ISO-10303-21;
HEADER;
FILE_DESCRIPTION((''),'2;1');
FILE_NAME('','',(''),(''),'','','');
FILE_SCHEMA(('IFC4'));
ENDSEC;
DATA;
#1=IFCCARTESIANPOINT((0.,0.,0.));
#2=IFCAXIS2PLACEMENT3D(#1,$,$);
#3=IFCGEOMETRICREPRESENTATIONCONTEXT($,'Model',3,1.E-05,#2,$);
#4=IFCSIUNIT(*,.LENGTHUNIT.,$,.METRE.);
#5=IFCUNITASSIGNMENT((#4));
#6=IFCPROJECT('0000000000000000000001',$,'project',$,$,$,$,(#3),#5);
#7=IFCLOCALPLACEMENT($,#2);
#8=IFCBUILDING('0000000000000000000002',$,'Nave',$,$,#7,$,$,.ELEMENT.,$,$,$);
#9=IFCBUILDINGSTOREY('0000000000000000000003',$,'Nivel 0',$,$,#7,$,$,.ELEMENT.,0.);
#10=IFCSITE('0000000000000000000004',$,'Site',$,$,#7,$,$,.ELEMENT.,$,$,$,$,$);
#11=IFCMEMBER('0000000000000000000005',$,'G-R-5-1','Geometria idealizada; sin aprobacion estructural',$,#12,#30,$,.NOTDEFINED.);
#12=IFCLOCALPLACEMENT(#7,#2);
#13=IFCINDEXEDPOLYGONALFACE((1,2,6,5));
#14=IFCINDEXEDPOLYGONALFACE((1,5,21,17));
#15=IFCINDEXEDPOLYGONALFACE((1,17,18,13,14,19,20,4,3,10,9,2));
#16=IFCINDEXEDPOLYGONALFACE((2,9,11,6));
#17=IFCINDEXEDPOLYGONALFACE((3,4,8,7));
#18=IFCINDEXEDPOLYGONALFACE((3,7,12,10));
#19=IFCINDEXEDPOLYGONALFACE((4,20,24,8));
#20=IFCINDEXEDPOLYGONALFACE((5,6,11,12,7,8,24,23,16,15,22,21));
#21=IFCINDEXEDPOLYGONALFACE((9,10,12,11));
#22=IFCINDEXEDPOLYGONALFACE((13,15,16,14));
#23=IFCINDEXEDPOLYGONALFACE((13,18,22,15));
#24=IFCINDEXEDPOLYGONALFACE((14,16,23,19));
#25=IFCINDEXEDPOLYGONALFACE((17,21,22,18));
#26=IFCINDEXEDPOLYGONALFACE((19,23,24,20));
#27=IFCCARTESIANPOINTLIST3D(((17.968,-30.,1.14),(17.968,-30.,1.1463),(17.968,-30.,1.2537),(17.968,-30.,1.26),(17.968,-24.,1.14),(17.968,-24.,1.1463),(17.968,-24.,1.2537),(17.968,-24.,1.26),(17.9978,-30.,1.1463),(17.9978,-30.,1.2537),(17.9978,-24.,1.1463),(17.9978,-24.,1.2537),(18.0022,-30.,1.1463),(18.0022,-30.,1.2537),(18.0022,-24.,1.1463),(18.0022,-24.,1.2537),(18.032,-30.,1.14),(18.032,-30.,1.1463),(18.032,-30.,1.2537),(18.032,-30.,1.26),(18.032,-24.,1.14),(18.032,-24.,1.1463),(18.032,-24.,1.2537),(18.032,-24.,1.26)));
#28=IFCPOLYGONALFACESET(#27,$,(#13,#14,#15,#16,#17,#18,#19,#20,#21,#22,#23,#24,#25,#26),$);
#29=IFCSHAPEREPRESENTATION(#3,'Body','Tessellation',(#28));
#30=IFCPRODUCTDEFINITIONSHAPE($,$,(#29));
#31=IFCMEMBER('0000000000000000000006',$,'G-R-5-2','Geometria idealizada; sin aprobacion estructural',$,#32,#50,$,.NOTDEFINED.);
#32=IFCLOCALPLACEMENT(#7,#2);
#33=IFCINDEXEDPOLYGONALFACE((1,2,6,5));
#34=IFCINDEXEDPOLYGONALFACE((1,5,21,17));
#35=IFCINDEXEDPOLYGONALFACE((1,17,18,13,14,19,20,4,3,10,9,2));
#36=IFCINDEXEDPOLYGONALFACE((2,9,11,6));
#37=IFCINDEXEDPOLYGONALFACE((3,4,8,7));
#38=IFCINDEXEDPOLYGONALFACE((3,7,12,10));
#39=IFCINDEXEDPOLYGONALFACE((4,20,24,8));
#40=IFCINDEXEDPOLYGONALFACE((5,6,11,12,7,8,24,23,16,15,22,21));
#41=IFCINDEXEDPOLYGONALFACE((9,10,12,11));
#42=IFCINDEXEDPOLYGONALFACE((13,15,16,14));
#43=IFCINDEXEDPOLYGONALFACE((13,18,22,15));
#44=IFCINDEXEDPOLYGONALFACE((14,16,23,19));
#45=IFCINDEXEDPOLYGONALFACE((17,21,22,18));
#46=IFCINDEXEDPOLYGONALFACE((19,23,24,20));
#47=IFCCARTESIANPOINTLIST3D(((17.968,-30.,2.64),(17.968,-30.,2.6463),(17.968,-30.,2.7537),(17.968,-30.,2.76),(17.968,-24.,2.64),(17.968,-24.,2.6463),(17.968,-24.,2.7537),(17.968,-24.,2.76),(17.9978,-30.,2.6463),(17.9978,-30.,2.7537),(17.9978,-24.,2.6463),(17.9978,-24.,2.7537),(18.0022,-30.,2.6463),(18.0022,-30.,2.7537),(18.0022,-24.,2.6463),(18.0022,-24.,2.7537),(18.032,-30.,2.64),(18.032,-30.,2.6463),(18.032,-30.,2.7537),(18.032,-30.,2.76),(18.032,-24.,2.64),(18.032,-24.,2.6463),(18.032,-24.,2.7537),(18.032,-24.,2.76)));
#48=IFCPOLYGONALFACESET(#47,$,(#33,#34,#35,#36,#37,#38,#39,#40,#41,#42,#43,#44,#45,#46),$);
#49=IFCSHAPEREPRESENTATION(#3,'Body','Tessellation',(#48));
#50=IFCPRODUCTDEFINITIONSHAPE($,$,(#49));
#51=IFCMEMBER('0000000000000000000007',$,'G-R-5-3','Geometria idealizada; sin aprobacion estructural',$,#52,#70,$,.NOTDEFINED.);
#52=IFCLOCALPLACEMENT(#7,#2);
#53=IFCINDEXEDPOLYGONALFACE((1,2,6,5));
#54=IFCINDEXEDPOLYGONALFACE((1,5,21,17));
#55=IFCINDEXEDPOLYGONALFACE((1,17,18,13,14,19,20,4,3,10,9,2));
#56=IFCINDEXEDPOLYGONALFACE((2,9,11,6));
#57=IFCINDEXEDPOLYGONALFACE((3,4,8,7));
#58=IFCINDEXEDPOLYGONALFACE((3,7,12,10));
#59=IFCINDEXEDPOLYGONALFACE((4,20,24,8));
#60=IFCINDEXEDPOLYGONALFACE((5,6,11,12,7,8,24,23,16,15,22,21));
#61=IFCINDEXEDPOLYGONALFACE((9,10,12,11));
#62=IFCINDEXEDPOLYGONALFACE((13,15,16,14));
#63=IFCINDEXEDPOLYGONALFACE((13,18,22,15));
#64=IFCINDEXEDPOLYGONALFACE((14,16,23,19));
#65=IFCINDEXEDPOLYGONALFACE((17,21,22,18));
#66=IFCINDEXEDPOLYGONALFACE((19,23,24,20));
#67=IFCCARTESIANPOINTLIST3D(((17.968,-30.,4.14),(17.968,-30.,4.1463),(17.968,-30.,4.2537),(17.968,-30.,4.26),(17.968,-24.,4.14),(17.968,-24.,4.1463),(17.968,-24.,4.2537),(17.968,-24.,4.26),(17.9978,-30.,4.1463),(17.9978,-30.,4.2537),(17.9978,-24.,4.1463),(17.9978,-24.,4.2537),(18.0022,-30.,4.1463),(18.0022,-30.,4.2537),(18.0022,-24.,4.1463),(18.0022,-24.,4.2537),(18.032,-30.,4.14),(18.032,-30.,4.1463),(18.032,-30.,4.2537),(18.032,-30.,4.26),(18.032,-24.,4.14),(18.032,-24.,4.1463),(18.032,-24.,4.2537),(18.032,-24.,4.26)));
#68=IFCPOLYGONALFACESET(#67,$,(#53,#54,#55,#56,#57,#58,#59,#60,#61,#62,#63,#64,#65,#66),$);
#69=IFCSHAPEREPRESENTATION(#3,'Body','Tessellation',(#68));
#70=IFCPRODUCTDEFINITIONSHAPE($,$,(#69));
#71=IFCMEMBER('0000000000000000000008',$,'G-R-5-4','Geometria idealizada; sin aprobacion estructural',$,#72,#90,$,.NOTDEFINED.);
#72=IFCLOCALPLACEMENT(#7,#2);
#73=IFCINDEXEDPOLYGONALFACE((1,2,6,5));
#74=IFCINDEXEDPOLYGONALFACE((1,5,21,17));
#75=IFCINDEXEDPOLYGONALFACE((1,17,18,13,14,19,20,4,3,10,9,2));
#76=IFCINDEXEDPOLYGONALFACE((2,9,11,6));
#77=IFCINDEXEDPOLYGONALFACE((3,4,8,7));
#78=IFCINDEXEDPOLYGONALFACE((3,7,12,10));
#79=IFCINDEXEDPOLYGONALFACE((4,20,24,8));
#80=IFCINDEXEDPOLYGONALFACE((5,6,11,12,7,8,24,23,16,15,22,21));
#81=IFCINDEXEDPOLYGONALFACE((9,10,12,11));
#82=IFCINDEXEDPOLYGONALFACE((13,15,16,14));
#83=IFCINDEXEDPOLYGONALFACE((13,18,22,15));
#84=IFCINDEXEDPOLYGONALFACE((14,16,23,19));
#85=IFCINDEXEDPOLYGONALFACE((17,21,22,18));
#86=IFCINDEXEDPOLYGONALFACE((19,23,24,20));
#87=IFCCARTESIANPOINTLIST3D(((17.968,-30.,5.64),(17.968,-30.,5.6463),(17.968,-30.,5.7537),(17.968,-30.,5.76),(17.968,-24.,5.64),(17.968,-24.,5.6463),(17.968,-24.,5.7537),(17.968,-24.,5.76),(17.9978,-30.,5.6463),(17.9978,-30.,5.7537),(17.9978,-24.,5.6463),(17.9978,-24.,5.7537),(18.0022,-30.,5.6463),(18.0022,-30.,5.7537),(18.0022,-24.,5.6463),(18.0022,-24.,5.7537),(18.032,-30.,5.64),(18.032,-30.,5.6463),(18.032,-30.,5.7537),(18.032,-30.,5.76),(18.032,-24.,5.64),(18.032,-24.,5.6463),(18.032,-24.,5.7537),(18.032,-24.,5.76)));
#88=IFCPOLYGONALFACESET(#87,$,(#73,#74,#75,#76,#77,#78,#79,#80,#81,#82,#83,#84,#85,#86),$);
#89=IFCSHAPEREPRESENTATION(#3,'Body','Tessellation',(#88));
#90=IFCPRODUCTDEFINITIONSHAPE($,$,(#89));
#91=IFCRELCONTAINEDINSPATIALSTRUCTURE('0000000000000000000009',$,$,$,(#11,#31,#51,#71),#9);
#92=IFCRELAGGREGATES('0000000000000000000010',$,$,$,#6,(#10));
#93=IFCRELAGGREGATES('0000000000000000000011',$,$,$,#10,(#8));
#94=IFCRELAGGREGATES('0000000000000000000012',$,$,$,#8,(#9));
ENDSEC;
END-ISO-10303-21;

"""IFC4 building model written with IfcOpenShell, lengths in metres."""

from ifc_helpers import new_model, si_unit, frame, origin, place, context, project, spatial, polyline, outline, extrude, element, save


model = new_model("IFC4")

# Units and contexts
model_context = context("Model", 3, precision=1e-05, world=origin())
ifc_project = project(units=[si_unit("LENGTHUNIT", "METRE")], contexts=[model_context])

# Site, building, storey
placement = place(None, origin())
site = spatial("IfcSite", under=ifc_project, at=placement, Name="Site", CompositionType="ELEMENT")
building = spatial("IfcBuilding", under=site, at=placement, Name="Nave", CompositionType="ELEMENT")
storey = spatial("IfcBuildingStorey", under=building, at=placement, Name="Nivel 0", CompositionType="ELEMENT", Elevation=0.0)

# Members
for number, where, z_axis, x_axis, name in (
    (1, (18.0, -24.0, 1.2), (0.0, -1.0, 0.0), (1.0, 0.0, 0.0), "G-R-5-1"),
    (2, (18.0, -24.0, 2.7), (0.0, -1.0, 0.0), (1.0, 0.0, 0.0), "G-R-5-2"),
    (3, (18.0, -24.0, 4.2), (0.0, -1.0, 0.0), (1.0, 0.0, 0.0), "G-R-5-3"),
    (4, (18.0, -24.0, 5.7), (0.0, -1.0, 0.0), (1.0, 0.0, 0.0), "G-R-5-4"),
):
    element("IfcMember", number, at=place(placement, frame(where, z_axis=z_axis, x_axis=x_axis)), inside=storey, Name=name, Description="Geometria idealizada; sin aprobacion estructural", PredefinedType="NOTDEFINED", context=model_context, shape_type="SweptSolid", body=[
        extrude(outline(polyline([(-0.032, -0.06), (0.032, -0.06), (0.032, -0.0537), (0.0022, -0.0537), (0.0022, 0.0537), (0.032, 0.0537), (0.032, 0.06), (-0.032, 0.06), (-0.032, 0.0537), (-0.0022, 0.0537), (-0.0022, -0.0537), (-0.032, -0.0537), (-0.032, -0.06)])), origin(), (0.0, 0.0, 1.0), 6.0),
    ])

save(model, "model.ifc")
